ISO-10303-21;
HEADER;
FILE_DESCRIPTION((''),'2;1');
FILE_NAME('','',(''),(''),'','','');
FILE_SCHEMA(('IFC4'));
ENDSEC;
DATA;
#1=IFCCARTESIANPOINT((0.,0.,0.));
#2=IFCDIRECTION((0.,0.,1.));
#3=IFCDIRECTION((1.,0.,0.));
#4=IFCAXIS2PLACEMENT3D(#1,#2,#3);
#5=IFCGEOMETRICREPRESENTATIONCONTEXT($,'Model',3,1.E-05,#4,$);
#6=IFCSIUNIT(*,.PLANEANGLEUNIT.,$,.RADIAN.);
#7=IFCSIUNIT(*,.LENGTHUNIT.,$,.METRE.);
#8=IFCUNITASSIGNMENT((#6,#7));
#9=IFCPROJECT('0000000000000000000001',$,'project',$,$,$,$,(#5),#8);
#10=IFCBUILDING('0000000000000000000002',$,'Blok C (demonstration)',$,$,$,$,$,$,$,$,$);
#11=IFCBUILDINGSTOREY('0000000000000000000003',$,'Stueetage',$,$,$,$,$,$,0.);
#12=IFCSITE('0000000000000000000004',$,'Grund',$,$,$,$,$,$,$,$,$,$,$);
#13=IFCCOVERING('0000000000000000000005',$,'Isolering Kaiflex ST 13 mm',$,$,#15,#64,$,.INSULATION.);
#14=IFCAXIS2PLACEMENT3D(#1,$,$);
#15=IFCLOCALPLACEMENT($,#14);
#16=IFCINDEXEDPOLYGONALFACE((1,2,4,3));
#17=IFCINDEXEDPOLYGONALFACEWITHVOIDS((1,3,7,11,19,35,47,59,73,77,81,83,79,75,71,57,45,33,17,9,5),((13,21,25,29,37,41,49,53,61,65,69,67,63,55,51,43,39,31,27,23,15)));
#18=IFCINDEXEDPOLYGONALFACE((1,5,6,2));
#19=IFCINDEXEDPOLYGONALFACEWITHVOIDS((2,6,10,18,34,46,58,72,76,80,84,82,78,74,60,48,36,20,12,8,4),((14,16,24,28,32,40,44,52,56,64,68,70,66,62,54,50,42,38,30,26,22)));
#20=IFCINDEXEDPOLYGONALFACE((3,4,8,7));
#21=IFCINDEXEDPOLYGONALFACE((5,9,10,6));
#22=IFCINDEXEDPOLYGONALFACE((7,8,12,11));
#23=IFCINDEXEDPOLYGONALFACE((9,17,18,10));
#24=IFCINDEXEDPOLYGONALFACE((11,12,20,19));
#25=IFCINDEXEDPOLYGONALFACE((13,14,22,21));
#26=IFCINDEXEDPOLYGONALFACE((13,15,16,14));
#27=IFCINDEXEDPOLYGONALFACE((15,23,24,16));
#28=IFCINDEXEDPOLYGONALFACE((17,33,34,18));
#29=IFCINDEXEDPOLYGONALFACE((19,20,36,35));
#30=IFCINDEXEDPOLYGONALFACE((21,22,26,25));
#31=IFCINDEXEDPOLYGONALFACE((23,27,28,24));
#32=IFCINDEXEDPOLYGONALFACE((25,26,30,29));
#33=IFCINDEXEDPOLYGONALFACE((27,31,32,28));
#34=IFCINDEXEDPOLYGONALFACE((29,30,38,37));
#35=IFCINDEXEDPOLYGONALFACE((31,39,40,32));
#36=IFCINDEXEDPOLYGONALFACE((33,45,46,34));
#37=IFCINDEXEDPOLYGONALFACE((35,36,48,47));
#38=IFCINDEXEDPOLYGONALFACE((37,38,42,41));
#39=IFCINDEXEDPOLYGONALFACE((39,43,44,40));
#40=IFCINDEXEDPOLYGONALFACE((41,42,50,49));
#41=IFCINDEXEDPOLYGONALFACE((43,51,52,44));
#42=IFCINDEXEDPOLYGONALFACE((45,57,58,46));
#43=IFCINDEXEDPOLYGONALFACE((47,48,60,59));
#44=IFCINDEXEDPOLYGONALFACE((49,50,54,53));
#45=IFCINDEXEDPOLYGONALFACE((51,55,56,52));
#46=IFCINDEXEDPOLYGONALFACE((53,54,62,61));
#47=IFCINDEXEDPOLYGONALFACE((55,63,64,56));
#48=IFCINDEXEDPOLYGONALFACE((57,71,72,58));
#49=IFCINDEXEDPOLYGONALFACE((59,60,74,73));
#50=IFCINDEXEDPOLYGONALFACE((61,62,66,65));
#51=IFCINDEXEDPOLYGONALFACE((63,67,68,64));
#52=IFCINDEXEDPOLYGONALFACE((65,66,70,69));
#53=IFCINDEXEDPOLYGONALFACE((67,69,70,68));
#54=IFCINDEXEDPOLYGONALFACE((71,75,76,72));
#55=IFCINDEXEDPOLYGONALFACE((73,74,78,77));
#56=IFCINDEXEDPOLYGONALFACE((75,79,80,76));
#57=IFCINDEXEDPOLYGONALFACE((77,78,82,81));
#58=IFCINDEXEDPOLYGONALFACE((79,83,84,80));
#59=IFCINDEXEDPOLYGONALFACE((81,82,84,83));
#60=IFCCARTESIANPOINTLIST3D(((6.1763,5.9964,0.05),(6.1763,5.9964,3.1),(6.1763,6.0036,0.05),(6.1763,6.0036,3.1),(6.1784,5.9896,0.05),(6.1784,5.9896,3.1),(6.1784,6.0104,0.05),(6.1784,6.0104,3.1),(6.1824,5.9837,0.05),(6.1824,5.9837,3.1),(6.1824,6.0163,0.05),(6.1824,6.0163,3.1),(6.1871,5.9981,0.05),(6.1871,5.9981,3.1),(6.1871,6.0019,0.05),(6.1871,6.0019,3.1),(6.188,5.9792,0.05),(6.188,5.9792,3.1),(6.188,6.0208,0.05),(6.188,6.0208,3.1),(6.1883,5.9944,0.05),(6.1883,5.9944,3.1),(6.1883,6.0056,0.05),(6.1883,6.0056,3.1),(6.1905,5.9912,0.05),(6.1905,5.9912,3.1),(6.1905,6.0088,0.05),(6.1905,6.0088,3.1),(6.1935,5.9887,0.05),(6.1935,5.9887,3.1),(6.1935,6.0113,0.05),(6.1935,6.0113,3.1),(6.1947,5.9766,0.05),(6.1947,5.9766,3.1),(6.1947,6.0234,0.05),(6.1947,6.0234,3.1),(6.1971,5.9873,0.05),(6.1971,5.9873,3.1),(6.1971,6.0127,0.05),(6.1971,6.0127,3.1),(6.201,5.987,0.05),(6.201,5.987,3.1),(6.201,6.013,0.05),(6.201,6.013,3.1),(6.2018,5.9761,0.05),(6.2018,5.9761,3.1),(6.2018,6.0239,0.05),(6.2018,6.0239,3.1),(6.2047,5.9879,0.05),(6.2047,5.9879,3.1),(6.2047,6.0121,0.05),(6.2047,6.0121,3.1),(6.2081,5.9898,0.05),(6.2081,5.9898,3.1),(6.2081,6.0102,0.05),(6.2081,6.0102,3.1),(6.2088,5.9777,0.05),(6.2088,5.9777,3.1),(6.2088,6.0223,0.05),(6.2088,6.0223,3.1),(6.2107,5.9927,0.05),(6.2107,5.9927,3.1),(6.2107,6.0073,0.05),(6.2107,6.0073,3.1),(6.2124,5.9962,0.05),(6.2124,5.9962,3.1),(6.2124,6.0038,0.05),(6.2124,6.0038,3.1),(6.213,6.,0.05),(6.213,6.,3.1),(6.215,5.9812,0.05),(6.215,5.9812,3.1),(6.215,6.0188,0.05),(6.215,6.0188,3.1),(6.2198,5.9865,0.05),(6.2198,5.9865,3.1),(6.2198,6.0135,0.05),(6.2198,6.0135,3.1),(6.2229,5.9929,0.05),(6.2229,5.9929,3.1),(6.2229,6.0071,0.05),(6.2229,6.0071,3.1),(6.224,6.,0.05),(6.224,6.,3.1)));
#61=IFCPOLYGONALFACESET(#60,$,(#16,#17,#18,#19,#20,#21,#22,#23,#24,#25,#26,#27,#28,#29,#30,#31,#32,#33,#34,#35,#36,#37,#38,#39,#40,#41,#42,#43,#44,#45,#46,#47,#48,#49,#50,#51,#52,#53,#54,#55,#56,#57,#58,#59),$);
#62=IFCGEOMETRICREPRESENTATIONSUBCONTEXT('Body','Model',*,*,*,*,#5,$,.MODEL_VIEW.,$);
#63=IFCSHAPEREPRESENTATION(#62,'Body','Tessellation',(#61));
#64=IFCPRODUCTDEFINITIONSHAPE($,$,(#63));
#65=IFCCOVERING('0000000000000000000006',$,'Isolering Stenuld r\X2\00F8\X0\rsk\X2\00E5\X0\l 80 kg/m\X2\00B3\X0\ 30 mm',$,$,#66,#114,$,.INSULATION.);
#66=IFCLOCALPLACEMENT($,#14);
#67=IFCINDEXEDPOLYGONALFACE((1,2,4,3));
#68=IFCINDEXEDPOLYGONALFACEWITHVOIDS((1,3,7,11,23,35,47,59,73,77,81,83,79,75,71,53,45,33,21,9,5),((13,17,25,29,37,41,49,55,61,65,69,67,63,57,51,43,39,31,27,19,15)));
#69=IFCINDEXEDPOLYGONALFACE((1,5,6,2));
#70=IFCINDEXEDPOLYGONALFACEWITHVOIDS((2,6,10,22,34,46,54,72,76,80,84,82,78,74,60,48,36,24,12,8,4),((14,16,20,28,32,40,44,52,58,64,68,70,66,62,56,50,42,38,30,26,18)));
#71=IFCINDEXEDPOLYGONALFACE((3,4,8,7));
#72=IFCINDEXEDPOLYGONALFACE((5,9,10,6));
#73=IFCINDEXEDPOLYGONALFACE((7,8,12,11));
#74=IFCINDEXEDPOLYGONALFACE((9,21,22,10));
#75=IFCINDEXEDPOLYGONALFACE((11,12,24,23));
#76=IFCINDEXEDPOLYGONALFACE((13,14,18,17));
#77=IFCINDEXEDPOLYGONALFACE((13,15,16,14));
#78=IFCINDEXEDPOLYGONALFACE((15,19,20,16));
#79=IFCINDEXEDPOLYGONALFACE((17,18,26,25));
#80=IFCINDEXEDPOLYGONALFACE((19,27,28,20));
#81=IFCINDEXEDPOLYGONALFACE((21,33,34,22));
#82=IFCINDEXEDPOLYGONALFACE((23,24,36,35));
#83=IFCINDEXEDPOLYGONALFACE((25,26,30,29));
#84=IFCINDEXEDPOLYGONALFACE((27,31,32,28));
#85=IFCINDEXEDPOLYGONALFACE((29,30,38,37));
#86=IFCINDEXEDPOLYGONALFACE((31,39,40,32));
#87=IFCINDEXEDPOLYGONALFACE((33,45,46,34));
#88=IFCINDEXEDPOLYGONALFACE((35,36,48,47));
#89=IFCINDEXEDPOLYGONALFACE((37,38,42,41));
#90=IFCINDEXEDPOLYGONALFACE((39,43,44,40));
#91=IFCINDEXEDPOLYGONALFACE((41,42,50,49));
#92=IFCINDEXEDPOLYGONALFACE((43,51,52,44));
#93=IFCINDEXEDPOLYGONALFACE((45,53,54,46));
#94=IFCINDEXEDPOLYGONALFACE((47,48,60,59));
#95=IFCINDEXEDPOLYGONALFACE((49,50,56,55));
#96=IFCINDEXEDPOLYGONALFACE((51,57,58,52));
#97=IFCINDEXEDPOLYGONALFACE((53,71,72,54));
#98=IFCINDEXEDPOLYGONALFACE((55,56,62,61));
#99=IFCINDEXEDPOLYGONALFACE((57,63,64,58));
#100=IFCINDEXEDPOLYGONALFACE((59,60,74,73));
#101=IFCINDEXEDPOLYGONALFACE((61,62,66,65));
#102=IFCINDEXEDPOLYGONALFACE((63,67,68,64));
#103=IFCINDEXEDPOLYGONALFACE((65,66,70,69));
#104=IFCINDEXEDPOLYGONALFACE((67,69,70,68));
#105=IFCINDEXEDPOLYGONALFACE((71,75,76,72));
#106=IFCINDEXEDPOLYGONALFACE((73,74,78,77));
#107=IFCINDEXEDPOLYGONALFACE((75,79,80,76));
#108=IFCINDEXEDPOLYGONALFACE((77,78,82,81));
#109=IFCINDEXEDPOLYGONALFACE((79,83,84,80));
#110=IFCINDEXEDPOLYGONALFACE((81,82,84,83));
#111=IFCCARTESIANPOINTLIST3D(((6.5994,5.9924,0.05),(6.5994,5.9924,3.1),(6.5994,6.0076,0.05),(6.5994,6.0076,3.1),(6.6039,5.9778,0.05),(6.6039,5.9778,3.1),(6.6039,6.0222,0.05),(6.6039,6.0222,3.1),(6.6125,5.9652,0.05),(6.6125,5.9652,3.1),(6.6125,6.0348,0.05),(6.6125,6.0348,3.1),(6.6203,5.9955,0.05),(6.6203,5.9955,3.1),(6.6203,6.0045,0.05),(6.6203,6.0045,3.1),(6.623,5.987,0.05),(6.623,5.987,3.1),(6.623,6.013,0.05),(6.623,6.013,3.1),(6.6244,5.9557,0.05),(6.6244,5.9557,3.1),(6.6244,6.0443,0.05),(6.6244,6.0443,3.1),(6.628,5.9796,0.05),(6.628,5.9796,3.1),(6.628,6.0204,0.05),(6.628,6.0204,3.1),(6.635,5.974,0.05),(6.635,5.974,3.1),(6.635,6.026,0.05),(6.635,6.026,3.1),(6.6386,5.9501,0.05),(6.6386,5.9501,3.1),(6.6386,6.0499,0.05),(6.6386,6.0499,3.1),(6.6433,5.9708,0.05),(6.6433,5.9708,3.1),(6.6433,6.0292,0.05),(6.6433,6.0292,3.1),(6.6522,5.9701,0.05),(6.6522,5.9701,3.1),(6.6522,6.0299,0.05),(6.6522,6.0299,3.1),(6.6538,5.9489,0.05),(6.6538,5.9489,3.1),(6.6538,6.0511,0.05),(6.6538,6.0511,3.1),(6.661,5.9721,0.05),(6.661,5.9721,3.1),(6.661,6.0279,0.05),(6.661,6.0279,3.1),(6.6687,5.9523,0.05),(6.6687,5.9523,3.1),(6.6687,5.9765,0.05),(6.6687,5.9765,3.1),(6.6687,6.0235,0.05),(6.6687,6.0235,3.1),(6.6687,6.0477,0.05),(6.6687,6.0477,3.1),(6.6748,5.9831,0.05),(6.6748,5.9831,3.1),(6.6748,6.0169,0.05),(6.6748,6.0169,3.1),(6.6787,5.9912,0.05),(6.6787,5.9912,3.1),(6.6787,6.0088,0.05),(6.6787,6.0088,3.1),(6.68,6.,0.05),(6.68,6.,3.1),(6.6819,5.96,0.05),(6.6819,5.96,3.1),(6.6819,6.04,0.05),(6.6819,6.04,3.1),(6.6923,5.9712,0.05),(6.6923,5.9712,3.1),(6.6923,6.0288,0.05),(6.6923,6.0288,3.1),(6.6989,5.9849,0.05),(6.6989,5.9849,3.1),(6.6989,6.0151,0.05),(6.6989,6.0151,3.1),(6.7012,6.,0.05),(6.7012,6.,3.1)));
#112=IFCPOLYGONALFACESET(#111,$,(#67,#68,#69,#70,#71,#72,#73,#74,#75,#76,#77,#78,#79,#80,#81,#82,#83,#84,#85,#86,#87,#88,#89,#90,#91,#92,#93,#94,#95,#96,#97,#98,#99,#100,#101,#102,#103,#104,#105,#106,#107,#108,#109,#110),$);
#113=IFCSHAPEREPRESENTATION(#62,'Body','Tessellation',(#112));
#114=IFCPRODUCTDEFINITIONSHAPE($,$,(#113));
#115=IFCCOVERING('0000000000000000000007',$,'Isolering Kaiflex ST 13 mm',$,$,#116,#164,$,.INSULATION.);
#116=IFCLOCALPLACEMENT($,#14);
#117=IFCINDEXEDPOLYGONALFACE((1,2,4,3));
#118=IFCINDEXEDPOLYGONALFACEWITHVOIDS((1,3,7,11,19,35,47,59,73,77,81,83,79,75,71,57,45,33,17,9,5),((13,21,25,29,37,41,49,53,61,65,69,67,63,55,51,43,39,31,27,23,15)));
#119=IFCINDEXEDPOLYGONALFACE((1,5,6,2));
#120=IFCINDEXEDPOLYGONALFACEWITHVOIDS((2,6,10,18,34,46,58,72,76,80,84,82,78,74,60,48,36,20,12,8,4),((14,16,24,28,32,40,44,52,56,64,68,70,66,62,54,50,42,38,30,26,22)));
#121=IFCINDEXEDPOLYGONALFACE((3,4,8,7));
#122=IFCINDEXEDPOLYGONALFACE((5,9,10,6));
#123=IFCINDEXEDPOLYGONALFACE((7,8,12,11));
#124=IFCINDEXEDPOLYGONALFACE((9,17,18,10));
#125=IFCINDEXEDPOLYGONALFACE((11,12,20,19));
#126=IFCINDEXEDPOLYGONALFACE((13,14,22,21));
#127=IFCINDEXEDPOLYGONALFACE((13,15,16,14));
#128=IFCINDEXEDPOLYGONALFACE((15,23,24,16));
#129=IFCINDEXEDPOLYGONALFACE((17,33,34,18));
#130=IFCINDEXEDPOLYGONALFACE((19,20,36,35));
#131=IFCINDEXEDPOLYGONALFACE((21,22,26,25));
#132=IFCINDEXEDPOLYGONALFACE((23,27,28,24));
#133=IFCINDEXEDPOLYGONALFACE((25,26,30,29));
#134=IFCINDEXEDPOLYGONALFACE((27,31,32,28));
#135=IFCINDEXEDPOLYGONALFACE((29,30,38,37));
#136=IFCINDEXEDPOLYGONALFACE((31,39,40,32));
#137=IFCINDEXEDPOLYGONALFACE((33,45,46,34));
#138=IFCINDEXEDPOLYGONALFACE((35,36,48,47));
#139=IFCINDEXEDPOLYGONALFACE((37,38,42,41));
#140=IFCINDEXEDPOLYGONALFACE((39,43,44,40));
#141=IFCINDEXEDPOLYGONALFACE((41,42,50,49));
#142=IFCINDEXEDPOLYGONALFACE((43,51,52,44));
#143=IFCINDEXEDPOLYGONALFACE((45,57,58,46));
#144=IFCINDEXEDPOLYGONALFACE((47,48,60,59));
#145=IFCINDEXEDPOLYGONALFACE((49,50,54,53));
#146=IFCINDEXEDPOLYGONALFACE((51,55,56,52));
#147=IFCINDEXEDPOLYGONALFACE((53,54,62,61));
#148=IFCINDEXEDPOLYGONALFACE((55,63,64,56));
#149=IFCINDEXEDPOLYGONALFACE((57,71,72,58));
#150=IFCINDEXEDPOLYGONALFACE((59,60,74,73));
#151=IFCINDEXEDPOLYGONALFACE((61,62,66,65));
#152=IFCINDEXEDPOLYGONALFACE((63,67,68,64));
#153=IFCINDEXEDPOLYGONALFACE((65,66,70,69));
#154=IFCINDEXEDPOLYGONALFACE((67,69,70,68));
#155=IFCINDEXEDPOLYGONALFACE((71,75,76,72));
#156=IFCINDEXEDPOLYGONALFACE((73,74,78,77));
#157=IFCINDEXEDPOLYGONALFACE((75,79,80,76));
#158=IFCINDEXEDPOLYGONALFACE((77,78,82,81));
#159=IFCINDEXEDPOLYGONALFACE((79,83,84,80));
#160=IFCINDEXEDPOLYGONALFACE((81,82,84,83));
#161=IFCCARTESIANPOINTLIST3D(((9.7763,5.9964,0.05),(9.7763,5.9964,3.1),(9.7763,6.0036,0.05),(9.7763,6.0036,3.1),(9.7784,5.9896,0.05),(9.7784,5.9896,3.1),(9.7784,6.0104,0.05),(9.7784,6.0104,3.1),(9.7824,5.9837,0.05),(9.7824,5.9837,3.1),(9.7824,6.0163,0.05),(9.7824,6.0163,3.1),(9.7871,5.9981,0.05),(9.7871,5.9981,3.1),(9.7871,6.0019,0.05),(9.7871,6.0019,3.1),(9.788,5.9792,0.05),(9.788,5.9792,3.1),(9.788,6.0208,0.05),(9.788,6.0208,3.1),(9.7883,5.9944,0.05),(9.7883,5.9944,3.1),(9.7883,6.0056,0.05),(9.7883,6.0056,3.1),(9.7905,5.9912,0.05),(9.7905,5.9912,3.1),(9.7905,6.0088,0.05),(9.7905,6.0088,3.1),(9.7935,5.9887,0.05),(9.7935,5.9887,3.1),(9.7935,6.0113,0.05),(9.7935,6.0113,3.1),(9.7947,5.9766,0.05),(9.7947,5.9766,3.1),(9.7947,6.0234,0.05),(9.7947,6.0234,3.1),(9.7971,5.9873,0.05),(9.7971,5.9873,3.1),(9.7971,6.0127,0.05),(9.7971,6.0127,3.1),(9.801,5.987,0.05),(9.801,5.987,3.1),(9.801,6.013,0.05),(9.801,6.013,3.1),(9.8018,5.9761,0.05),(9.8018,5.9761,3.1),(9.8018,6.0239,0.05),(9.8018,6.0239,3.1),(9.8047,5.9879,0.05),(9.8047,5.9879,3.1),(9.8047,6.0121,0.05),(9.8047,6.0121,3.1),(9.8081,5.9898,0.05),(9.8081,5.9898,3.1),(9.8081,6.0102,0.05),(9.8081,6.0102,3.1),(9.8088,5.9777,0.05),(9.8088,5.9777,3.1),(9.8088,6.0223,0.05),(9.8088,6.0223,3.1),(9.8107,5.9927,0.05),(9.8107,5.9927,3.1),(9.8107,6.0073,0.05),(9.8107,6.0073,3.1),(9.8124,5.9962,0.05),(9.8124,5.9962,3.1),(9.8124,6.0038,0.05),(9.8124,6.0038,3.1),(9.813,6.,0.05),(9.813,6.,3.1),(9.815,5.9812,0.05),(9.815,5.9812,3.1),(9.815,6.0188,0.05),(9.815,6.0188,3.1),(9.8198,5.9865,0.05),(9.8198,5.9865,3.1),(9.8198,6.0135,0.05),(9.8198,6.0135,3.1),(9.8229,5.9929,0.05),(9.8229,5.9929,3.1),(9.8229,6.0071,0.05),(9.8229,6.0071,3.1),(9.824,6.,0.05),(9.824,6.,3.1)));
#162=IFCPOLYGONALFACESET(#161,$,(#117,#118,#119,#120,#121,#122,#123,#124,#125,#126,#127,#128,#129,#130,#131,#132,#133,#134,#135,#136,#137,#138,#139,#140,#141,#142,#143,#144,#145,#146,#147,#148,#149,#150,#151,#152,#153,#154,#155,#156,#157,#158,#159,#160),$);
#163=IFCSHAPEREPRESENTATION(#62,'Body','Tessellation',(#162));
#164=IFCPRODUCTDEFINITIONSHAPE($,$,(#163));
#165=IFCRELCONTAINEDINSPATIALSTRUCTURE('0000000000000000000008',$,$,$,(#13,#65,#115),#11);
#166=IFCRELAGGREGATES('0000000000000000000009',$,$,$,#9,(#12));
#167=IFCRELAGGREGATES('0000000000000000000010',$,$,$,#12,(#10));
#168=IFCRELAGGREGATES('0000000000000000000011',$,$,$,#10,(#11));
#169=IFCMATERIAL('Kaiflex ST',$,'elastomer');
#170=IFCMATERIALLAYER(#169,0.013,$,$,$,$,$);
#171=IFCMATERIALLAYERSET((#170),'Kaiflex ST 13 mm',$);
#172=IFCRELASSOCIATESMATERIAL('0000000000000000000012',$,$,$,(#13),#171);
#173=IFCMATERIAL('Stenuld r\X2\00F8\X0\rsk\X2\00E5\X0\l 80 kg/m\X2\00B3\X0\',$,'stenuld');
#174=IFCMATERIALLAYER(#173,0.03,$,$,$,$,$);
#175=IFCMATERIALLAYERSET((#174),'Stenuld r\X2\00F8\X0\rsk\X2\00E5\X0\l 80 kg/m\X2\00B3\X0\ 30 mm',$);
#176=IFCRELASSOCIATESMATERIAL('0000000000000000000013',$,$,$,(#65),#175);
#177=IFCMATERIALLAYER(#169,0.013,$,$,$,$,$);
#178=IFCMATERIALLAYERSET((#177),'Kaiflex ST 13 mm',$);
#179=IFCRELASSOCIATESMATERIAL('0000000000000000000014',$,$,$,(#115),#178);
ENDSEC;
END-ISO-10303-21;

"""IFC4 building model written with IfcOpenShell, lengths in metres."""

from ifc_helpers import new_model, si_unit, frame, origin_with_axes, place, context, subcontext, project, spatial, hollow_circle, extrude, material, layer, layer_set, element, save


model = new_model("IFC4")

# Units and contexts
model_context = context("Model", 3, precision=1e-05, world=origin_with_axes())
body_context = subcontext(model_context, "Body", "Model", "MODEL_VIEW")
ifc_project = project(units=[si_unit("PLANEANGLEUNIT", "RADIAN"), si_unit("LENGTHUNIT", "METRE")], contexts=[model_context])

# Site, building, storey
site = spatial("IfcSite", under=ifc_project, Name="Grund")
building = spatial("IfcBuilding", under=site, Name="Blok C (demonstration)")
storey = spatial("IfcBuildingStorey", under=building, Name="Stueetage", Elevation=0.0)

# Coverings
ifc_material_1 = material(Name="Kaiflex ST", Category="elastomer")
ifc_layer_1 = layer(ifc_material_1, 0.013)
ifc_layer_set_1 = layer_set([ifc_layer_1], Name="Kaiflex ST 13 mm")
covering_1_placement = place(None, origin_with_axes())
element("IfcCovering", 1, at=covering_1_placement, inside=storey, material=ifc_layer_set_1, Name="Isolering Kaiflex ST 13 mm", PredefinedType="INSULATION", context=body_context, shape_type="SweptSolid", body=[
    extrude(hollow_circle(Radius=0.024, WallThickness=0.011), frame((6.2, 6.0, 0.05), z_axis=(0.0, 0.0, 1.0), x_axis=(1.0, 0.0, 0.0)), (0.0, 0.0, 1.0), 3.05),
])
ifc_material_2 = material(Name="Stenuld rørskål 80 kg/m³", Category="stenuld")
ifc_layer_2 = layer(ifc_material_2, 0.03)
ifc_layer_set_2 = layer_set([ifc_layer_2], Name="Stenuld rørskål 80 kg/m³ 30 mm")
covering_2_placement = place(None, origin_with_axes())
element("IfcCovering", 2, at=covering_2_placement, inside=storey, material=ifc_layer_set_2, Name="Isolering Stenuld rørskål 80 kg/m³ 30 mm", PredefinedType="INSULATION", context=body_context, shape_type="SweptSolid", body=[
    extrude(hollow_circle(Radius=0.0512, WallThickness=0.0212), frame((6.65, 6.0, 0.05), z_axis=(0.0, 0.0, 1.0), x_axis=(1.0, 0.0, 0.0)), (0.0, 0.0, 1.0), 3.05),
])
ifc_layer_3 = layer(ifc_material_1, 0.013)
ifc_layer_set_3 = layer_set([ifc_layer_3], Name="Kaiflex ST 13 mm")
covering_3_placement = place(None, origin_with_axes())
element("IfcCovering", 3, at=covering_3_placement, inside=storey, material=ifc_layer_set_3, Name="Isolering Kaiflex ST 13 mm", PredefinedType="INSULATION", context=body_context, shape_type="SweptSolid", body=[
    extrude(hollow_circle(Radius=0.024, WallThickness=0.011), frame((9.8, 6.0, 0.05), z_axis=(0.0, 0.0, 1.0), x_axis=(1.0, 0.0, 0.0)), (0.0, 0.0, 1.0), 3.05),
])

save(model, "model.ifc")
